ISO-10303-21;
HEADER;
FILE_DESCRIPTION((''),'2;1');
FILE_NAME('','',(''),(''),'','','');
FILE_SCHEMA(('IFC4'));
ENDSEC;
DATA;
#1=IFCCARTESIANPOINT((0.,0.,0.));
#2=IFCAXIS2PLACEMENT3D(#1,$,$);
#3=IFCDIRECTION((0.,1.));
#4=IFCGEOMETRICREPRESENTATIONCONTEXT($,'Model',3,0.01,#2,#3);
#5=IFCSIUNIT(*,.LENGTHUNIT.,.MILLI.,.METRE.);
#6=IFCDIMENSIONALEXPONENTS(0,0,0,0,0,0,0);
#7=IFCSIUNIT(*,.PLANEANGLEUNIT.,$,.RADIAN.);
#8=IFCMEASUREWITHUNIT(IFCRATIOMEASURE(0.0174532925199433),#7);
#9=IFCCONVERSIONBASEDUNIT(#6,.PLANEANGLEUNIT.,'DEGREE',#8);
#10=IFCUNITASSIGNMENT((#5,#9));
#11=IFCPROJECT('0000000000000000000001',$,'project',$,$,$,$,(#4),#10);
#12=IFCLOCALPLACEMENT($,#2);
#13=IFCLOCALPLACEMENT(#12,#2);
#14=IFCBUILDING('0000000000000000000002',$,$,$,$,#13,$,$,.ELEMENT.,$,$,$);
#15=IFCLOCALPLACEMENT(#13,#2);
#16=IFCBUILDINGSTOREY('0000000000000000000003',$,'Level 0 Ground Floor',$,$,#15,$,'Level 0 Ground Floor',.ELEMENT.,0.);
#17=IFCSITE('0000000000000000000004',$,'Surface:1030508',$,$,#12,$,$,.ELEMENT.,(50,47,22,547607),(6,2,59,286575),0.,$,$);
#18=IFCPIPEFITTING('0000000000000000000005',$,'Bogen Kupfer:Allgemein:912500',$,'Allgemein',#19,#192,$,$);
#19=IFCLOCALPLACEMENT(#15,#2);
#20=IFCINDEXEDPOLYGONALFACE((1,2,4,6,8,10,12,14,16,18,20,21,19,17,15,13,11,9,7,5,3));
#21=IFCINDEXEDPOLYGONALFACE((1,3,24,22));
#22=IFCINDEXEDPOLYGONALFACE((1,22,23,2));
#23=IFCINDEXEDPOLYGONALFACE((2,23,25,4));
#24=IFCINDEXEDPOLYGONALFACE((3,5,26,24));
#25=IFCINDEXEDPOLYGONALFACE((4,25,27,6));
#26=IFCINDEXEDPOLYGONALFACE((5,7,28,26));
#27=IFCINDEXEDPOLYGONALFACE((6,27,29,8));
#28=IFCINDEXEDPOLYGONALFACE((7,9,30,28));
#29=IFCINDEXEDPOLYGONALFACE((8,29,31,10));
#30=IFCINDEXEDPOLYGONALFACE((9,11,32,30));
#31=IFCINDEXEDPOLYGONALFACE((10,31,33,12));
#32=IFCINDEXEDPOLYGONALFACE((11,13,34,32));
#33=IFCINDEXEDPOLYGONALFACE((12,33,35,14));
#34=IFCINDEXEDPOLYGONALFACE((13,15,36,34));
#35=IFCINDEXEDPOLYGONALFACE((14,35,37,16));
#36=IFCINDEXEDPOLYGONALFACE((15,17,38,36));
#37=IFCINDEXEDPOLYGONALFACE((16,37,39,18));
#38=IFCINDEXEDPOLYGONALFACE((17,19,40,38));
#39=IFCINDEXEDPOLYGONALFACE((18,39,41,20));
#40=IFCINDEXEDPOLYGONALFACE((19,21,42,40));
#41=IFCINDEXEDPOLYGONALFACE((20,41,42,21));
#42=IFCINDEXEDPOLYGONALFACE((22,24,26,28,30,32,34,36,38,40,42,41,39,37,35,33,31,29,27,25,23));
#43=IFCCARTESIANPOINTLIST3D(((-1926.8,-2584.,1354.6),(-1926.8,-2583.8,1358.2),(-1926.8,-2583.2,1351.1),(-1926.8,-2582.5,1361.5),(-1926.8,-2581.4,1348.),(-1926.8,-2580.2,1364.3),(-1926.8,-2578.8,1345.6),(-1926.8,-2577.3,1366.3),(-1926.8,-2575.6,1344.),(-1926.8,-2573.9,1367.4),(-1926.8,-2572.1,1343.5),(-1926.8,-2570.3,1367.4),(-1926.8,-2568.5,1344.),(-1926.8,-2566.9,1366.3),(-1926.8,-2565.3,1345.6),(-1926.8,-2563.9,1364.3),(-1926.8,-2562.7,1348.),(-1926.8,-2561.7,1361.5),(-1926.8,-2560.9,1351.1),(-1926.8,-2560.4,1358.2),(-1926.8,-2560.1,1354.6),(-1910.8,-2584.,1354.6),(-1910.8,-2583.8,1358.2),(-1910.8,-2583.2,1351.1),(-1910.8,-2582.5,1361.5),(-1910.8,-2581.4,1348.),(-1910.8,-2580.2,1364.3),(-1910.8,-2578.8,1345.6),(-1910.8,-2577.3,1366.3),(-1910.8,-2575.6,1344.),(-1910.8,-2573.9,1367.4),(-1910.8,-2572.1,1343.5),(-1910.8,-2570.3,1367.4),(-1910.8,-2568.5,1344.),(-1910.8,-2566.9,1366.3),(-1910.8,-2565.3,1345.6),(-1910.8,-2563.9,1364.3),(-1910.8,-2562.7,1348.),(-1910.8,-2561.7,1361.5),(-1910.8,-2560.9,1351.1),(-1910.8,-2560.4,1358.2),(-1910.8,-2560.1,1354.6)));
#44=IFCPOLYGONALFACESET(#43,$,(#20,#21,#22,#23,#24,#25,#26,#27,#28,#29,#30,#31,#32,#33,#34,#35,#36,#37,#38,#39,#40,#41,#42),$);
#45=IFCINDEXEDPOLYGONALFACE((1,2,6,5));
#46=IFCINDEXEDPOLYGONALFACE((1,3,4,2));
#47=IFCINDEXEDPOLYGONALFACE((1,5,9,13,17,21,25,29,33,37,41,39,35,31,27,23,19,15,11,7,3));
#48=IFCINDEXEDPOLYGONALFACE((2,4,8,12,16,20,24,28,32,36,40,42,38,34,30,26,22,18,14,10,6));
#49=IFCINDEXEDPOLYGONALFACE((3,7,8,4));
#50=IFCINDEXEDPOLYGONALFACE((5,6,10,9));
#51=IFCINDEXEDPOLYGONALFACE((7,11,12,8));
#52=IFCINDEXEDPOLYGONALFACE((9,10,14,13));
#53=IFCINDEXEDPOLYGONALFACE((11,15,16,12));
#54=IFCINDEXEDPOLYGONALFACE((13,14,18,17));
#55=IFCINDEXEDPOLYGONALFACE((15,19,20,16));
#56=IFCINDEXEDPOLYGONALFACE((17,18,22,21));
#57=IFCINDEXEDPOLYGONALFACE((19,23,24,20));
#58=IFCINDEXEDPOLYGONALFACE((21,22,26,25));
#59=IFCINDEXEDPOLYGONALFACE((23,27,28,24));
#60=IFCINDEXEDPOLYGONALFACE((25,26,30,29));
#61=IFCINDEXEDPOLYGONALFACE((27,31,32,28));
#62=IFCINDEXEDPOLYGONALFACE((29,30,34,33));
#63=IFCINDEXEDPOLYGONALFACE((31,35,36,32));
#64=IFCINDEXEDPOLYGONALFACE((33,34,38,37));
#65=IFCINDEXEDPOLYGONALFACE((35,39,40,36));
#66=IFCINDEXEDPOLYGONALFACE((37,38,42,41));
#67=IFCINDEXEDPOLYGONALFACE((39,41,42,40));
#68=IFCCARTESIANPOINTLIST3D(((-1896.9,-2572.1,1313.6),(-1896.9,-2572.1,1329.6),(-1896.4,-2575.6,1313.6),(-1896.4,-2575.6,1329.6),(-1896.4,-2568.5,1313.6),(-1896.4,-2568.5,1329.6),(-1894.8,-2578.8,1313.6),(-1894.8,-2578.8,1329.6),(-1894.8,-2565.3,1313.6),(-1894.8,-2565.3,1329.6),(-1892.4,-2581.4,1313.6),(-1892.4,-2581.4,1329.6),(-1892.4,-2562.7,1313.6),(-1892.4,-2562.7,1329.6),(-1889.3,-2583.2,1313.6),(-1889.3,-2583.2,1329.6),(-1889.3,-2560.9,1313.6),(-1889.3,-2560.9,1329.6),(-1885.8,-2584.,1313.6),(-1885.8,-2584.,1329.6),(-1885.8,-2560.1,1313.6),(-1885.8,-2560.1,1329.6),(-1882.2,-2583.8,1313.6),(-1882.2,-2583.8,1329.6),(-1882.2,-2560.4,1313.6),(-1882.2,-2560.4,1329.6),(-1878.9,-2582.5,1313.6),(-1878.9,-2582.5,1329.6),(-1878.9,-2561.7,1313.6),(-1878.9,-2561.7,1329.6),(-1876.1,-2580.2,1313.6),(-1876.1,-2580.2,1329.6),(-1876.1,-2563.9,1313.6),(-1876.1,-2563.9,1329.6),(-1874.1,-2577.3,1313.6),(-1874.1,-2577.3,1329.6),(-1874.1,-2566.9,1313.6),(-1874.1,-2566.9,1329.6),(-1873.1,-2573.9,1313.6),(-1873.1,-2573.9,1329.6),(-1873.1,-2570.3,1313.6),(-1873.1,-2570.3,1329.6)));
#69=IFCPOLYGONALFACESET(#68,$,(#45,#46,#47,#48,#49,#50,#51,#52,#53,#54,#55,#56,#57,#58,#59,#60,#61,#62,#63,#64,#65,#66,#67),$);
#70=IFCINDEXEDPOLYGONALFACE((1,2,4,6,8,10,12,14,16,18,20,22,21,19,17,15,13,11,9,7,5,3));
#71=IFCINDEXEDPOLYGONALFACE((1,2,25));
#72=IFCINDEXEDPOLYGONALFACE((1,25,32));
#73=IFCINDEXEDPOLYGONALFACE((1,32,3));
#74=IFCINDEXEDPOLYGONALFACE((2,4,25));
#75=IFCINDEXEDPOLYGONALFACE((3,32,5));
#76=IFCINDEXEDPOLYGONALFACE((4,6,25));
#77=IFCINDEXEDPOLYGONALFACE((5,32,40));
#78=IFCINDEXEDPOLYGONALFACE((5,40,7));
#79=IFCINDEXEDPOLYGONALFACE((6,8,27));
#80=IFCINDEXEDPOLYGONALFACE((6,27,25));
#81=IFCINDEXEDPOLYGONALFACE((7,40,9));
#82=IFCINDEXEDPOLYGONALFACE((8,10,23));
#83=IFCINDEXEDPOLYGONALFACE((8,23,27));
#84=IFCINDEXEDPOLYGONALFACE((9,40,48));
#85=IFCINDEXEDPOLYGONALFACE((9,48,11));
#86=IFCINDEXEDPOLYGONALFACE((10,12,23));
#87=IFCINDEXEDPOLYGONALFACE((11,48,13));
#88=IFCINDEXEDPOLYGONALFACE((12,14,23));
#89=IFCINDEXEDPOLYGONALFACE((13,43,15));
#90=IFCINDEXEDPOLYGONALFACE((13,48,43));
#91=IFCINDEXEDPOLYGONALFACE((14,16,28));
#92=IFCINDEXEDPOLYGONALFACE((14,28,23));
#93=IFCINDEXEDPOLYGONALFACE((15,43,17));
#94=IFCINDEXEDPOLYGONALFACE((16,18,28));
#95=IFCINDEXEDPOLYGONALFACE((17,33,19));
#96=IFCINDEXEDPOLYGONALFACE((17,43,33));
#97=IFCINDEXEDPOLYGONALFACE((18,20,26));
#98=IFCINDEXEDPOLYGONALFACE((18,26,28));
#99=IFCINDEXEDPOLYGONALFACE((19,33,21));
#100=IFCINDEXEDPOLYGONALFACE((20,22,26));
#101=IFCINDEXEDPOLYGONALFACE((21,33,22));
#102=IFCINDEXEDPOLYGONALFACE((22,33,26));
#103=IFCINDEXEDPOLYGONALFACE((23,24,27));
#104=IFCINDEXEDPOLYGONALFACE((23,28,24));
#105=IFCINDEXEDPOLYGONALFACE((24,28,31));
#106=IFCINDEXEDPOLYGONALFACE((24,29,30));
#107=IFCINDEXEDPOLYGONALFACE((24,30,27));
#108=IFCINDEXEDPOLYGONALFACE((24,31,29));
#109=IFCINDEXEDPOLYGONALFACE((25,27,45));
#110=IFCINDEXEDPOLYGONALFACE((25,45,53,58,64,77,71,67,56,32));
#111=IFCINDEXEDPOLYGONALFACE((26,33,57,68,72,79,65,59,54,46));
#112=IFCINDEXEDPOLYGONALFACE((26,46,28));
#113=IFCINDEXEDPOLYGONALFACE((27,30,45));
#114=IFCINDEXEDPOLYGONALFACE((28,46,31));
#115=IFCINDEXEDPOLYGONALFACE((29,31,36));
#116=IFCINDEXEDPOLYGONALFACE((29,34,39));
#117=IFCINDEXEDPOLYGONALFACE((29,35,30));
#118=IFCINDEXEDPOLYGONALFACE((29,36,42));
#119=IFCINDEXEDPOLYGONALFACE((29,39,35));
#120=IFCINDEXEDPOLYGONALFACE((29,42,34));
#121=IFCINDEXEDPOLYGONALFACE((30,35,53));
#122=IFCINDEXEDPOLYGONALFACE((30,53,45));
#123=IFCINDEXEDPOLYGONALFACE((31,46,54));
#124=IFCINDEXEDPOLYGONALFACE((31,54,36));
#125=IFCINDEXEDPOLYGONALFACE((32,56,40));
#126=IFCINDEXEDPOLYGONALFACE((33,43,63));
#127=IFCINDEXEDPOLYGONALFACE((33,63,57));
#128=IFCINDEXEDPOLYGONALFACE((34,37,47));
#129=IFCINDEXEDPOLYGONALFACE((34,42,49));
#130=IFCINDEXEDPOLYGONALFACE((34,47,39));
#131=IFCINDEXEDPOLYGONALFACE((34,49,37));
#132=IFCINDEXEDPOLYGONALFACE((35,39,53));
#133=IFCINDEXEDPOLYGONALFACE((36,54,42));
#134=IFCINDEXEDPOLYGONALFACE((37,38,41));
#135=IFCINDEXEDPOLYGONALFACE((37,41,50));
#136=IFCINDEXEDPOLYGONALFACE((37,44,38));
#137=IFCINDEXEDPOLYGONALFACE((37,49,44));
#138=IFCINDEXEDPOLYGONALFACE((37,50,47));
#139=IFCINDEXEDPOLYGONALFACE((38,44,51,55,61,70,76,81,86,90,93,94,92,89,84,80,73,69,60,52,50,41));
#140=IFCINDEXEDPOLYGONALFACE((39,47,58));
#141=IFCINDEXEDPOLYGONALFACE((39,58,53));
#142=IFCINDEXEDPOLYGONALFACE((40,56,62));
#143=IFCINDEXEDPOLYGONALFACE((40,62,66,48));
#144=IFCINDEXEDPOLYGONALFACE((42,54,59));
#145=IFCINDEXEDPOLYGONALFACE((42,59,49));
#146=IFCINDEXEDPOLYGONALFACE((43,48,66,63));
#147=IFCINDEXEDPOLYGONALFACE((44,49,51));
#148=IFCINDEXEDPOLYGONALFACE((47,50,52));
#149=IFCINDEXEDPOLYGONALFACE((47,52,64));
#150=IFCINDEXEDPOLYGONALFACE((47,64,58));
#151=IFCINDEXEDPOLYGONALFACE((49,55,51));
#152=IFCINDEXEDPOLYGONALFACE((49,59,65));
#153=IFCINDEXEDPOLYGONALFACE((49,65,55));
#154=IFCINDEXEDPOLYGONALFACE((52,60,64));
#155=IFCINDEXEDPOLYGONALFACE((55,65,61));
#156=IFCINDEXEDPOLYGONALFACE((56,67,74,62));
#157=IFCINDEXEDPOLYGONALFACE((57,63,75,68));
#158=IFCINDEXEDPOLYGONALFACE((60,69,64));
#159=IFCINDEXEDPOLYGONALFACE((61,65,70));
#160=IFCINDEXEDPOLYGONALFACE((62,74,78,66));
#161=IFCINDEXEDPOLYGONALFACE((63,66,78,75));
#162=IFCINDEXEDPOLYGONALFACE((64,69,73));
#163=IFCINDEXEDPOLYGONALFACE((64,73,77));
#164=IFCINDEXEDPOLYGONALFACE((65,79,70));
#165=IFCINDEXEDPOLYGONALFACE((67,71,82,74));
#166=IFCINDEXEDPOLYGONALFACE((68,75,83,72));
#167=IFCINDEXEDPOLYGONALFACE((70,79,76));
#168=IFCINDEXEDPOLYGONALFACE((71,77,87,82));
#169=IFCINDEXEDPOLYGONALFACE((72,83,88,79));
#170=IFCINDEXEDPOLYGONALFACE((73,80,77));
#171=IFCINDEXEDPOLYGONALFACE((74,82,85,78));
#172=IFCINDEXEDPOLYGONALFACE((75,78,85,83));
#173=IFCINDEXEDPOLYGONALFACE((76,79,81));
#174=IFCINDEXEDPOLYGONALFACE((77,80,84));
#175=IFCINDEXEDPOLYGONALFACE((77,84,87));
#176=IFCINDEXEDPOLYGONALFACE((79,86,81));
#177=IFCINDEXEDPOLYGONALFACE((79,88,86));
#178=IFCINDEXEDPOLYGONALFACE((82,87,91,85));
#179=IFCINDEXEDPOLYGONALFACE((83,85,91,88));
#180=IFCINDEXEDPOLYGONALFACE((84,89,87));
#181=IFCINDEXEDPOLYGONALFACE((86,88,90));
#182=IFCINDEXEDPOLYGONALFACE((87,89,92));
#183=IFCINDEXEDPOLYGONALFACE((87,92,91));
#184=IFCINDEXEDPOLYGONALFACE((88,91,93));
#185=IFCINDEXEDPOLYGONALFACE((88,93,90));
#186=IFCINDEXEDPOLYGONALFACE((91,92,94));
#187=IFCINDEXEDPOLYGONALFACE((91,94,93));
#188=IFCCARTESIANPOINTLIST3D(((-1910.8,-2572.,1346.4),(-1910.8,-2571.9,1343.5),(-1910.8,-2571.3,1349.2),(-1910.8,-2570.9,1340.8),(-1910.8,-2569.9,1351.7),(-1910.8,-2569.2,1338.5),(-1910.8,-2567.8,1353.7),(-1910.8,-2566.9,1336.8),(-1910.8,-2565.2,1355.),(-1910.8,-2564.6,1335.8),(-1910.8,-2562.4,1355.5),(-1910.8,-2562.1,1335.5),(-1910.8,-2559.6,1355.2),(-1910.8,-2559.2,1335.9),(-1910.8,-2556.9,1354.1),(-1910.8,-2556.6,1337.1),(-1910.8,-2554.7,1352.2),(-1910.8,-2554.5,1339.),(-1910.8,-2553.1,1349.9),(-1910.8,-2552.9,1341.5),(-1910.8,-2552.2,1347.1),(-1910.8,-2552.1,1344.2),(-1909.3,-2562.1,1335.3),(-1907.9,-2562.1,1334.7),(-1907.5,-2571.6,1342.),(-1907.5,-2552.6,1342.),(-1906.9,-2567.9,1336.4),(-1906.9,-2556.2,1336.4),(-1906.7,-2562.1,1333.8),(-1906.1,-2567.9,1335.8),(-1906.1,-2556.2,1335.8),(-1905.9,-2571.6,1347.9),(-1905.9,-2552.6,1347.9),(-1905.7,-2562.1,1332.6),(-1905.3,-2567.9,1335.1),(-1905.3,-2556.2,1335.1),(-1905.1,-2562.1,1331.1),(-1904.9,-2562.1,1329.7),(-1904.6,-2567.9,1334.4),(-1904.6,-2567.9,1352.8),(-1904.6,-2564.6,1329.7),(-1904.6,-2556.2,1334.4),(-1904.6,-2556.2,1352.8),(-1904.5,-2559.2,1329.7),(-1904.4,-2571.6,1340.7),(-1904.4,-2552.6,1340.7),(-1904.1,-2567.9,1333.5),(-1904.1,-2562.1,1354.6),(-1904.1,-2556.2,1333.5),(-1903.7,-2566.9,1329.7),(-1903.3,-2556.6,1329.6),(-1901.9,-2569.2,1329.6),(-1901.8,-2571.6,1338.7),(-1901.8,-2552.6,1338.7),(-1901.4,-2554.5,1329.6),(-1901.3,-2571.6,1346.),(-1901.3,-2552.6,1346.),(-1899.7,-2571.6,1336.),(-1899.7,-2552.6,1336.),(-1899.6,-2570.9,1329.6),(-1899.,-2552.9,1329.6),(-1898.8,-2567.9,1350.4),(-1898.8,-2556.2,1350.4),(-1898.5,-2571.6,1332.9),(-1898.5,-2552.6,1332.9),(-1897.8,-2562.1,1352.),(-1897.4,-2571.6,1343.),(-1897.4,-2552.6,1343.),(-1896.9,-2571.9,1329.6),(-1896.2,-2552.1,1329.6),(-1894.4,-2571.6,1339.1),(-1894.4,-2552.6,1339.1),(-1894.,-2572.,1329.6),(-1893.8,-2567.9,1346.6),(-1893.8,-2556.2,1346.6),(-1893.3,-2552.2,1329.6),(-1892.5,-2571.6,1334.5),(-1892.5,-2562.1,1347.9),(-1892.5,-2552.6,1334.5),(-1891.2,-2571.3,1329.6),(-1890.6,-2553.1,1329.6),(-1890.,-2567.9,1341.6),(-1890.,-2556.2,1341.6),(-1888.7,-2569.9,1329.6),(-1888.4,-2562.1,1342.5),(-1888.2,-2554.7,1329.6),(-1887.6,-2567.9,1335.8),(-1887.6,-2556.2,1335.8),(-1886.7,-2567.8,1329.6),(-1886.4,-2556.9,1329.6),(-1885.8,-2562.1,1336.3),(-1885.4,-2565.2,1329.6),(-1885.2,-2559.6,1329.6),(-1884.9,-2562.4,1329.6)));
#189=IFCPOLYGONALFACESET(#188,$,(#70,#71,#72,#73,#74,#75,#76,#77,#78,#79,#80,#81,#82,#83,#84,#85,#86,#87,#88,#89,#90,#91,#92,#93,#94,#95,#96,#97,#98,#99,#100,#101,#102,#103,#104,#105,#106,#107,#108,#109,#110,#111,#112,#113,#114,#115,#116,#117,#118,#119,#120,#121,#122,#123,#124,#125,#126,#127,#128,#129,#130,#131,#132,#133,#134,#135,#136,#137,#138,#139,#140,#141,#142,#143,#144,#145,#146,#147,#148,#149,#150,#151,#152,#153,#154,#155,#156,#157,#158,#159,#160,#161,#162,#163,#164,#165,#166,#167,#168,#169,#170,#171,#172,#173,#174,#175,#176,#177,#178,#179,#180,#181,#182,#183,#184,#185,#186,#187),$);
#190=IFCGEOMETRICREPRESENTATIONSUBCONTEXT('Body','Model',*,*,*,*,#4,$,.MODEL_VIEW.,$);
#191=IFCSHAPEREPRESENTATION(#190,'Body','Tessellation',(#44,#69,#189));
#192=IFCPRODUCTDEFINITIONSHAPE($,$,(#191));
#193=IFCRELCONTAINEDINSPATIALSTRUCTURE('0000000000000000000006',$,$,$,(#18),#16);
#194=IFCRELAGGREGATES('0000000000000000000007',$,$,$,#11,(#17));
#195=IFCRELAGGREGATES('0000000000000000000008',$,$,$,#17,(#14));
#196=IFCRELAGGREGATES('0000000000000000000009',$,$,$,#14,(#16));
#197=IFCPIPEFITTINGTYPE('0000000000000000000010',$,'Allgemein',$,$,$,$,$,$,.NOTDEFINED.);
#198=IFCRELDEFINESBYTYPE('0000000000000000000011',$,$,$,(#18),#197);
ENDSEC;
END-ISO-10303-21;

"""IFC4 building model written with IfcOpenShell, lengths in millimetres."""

from ifc_helpers import new_model, entity, si_unit, converted_unit, direction, frame, frame_2d, origin, place, context, subcontext, project, spatial, circle, extrude, source, transform, mapped, type_object, type_shapes, element, save


model = new_model("IFC4")

# Units and contexts
model_context = context("Model", 3, precision=0.01, world=origin(), true_north=direction((0.0, 1.0)))
body_context = subcontext(model_context, "Body", "Model", "MODEL_VIEW")
ifc_project = project(units=[si_unit("LENGTHUNIT", "METRE", prefix="MILLI"), converted_unit("PLANEANGLEUNIT", "DEGREE", entity("IfcRatioMeasure", 0.0174532925199433), si_unit("PLANEANGLEUNIT", "RADIAN"), dimensions=[0, 0, 0, 0, 0, 0, 0])], contexts=[model_context])

# Site, building, storey
site_placement = place(None, origin())
site = spatial("IfcSite", under=ifc_project, at=site_placement, Name="Surface:1030508", CompositionType="ELEMENT", RefLatitude=(50, 47, 22, 547607), RefLongitude=(6, 2, 59, 286575), RefElevation=0.0)
building_placement = place(site_placement, origin())
building = spatial("IfcBuilding", under=site, at=building_placement, CompositionType="ELEMENT")
storey_placement = place(building_placement, origin())
storey = spatial("IfcBuildingStorey", under=building, at=storey_placement, Name="Level 0 Ground Floor", LongName="Level 0 Ground Floor", CompositionType="ELEMENT", Elevation=0.0)

# Pipe fitting
pipe_fitting_type_1 = type_object("IfcPipeFittingType", Name="Allgemein", PredefinedType="NOTDEFINED")
ifc_direction_1 = entity("IfcDirection", [0.0, 0.0, -1.0])
trimmed_curve_1 = entity("IfcTrimmedCurve", entity("IfcCircle", entity("IfcAxis2Placement2D", entity("IfcCartesianPoint", [-15.9, 0.0]), entity("IfcDirection", [0.000076, 1.0])), 15.9), [entity("IfcParameterValue", 270.004326)], [entity("IfcParameterValue", 0.0)], True, "PARAMETER")
shared_shape_1 = source(origin(), body_context, "Body", "SolidModel", [
    extrude(circle(Radius=12.0, at=frame_2d((0.0, 0.0), x_axis=(1.0, 0.0))), frame((0.0, 25.9, 0.0), z_axis=(0.000076, 1.0, 0.0), x_axis=(-1.0, 0.000076, 0.0)), (0.0, 0.0, 1.0), 16.0),
    extrude(circle(Radius=12.0, at=frame_2d((0.0, 0.0), x_axis=(1.0, 0.0))), frame((-41.9, 0.0, 0.0), z_axis=(1.0, 0.0, 0.0), x_axis=(0.0, 1.0, 0.0)), (0.0, 0.0, 1.0), 16.0),
    entity("IfcSurfaceCurveSweptAreaSolid", entity("IfcCircleProfileDef", "AREA", None, entity("IfcAxis2Placement2D", entity("IfcCartesianPoint", [0.0, 10.0]), entity("IfcDirection", [1.0, 0.0])), 10.0), entity("IfcAxis2Placement3D", entity("IfcCartesianPoint", [-10.0, 25.9, 0.0]), ifc_direction_1, entity("IfcDirection", [1.0, -0.000076, 0.0])), trimmed_curve_1, 0.0, 90.0, entity("IfcSurfaceOfLinearExtrusion", entity("IfcArbitraryOpenProfileDef", "CURVE", None, trimmed_curve_1), entity("IfcAxis2Placement3D", entity("IfcCartesianPoint", [0.0, 0.0, -304.8])), ifc_direction_1, 1.0)),
])
type_shapes(pipe_fitting_type_1, [shared_shape_1])
pipe_fitting_1_placement = place(storey_placement, frame((-1884.9, -2572.1, 1355.5), z_axis=(0.0, -1.0, 0.0), x_axis=(0.0, 0.0, 1.0)))
element("IfcPipeFitting", 1, at=pipe_fitting_1_placement, inside=storey, type_object=pipe_fitting_type_1, Name="Bogen Kupfer:Allgemein:912500", ObjectType="Allgemein", context=body_context, shape_type="MappedRepresentation", body=[
    mapped(shared_shape_1, transform((0.0, 0.0, 0.0), scale=1.0)),
])

save(model, "model.ifc")
